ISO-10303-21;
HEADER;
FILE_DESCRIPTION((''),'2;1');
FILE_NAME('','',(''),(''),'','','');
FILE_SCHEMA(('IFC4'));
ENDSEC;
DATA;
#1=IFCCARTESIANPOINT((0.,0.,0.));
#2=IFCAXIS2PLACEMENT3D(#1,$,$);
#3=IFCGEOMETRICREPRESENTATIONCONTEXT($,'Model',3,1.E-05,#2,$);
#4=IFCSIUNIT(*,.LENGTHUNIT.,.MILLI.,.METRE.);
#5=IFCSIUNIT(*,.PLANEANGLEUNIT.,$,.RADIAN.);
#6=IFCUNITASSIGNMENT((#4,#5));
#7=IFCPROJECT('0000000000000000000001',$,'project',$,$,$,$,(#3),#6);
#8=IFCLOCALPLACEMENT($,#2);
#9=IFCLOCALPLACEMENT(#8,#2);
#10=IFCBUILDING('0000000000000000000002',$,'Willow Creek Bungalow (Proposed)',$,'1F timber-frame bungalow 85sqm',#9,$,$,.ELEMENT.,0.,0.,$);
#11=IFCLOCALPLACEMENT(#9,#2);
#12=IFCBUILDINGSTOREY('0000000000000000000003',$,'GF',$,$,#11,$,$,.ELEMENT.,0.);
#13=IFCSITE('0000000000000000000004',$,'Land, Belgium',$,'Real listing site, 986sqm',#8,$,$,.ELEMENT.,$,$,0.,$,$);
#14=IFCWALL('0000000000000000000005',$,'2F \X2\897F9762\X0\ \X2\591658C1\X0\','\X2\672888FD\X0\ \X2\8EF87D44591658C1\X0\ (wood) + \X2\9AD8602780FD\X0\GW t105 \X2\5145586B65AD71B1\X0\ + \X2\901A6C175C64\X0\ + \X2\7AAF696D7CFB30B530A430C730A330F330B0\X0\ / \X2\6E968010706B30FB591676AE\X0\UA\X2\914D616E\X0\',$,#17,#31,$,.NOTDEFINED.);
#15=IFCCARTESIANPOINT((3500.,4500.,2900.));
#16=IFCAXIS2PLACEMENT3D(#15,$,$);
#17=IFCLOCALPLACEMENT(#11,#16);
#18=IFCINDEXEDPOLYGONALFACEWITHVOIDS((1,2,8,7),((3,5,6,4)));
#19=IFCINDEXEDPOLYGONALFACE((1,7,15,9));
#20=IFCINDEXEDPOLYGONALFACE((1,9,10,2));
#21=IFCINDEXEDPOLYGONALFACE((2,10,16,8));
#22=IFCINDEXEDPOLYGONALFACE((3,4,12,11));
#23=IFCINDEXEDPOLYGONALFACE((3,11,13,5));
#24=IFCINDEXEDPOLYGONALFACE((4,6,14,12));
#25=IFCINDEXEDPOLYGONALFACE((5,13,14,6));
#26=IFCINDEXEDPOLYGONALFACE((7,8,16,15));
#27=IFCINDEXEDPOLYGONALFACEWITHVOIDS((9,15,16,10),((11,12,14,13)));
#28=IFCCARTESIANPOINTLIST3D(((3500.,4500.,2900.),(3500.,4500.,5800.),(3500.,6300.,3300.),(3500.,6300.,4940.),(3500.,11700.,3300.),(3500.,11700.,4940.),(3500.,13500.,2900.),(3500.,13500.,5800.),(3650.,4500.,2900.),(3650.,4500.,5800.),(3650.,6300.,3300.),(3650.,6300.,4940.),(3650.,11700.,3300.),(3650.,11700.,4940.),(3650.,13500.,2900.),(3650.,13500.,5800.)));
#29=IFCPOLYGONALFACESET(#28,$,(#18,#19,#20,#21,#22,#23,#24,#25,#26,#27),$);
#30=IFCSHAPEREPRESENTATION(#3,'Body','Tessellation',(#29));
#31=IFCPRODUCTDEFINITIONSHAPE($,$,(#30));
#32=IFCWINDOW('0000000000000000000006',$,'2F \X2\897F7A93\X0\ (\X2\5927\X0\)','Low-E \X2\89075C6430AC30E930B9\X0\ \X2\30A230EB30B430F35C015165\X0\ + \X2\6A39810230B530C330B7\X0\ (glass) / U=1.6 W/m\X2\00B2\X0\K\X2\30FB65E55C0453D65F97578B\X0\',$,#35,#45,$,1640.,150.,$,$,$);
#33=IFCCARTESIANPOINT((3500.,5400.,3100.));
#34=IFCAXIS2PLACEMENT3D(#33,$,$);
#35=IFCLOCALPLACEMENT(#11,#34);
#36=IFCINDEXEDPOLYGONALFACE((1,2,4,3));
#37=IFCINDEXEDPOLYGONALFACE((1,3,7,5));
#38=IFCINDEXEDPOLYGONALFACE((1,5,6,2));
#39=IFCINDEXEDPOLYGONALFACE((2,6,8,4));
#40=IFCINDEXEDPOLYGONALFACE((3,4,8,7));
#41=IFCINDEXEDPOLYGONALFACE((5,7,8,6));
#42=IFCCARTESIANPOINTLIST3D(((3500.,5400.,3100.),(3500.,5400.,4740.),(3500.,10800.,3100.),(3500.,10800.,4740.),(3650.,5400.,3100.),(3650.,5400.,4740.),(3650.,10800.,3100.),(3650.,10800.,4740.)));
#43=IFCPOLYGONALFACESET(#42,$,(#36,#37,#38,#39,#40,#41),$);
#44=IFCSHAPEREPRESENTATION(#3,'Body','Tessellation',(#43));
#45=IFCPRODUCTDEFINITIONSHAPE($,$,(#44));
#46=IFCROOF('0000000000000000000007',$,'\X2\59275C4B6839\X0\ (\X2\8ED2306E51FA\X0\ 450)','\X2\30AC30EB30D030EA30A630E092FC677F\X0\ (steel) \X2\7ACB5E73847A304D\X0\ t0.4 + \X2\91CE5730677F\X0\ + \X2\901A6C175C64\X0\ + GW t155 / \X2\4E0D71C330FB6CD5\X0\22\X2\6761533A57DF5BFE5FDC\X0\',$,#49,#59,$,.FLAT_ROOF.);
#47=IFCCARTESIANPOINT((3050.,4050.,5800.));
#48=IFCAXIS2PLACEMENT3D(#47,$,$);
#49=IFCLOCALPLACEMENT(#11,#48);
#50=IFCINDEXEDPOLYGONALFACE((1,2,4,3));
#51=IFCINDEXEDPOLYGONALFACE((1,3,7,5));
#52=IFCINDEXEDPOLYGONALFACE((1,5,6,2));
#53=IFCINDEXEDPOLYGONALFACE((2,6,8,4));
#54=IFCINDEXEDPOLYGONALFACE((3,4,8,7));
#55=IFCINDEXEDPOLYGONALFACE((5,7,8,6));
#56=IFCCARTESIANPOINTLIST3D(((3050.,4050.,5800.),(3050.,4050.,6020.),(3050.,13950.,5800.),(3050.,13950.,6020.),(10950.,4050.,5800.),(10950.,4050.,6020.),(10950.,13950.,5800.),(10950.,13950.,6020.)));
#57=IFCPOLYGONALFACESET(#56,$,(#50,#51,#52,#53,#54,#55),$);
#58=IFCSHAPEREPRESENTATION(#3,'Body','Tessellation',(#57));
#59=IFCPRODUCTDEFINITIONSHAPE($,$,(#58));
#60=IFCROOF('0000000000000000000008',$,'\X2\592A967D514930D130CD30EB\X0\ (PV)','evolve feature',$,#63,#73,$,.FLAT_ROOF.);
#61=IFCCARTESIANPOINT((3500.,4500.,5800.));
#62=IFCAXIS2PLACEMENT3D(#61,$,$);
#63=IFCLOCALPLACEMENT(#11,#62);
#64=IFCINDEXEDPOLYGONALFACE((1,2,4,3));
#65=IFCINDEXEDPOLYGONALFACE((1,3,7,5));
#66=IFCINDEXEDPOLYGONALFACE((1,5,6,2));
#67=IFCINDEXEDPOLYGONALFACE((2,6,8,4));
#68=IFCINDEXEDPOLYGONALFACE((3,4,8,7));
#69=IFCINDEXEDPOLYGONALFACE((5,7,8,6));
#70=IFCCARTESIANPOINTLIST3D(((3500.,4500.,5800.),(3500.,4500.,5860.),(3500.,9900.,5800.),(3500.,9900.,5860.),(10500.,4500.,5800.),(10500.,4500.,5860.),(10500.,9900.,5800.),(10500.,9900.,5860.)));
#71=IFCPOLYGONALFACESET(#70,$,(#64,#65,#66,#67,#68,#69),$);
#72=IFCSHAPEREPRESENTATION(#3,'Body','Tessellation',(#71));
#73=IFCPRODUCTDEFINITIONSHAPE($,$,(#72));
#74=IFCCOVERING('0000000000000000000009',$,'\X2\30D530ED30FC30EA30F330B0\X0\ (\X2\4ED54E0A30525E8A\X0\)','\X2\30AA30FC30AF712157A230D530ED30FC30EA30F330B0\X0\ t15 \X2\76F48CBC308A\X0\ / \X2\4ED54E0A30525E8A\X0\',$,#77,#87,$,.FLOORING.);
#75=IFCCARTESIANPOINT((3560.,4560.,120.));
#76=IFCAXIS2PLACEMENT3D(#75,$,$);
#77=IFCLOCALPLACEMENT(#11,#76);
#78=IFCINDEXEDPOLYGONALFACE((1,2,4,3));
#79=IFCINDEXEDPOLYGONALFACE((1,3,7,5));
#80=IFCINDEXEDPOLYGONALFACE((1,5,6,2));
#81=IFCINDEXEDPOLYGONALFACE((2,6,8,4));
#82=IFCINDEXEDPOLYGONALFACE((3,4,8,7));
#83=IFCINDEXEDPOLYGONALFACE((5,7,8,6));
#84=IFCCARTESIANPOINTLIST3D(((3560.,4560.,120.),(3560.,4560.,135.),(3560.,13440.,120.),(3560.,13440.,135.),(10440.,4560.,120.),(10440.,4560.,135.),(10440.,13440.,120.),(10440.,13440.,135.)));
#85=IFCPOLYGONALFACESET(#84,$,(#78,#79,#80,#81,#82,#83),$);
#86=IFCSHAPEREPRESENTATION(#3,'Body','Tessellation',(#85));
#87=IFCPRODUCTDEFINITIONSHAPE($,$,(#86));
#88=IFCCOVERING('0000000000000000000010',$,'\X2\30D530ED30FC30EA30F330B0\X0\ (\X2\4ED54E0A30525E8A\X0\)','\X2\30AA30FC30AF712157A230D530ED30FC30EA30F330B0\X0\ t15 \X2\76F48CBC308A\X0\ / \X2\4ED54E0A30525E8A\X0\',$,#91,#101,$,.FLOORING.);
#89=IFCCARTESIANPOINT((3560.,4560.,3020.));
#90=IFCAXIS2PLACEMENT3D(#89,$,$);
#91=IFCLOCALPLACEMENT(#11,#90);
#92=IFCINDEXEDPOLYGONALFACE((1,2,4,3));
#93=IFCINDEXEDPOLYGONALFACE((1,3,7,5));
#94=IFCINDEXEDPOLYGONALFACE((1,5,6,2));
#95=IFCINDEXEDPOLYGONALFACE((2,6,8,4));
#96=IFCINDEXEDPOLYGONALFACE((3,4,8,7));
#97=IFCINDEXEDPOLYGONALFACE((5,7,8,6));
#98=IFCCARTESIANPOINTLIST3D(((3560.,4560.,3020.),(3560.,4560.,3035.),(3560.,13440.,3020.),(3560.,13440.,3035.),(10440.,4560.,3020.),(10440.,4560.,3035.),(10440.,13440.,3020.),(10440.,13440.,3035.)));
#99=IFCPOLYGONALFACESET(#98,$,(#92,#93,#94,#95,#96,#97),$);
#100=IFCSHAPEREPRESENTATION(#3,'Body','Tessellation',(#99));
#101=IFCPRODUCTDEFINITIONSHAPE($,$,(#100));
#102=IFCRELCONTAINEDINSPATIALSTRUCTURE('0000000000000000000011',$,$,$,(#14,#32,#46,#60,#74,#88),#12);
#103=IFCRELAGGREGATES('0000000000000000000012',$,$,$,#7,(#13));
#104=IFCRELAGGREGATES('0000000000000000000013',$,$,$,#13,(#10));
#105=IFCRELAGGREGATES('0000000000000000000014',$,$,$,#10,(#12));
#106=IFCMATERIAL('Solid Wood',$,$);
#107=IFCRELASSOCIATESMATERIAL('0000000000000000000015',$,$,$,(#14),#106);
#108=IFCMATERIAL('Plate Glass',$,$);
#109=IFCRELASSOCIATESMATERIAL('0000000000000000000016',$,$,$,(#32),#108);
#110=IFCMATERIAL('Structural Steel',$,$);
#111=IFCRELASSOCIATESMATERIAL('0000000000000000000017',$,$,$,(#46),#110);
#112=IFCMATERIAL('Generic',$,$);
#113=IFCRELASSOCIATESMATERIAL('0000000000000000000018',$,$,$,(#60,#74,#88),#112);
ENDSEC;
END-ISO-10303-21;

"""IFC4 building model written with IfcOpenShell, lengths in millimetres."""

from ifc_helpers import new_model, si_unit, frame, frame_2d, origin, place, context, project, spatial, rectangle, extrude, material, element, fill, save


model = new_model("IFC4")

# Units and contexts
model_context = context("Model", 3, precision=1e-05, world=origin())
ifc_project = project(units=[si_unit("LENGTHUNIT", "METRE", prefix="MILLI"), si_unit("PLANEANGLEUNIT", "RADIAN")], contexts=[model_context])

# Site, building, storey
site_placement = place(None, origin())
site = spatial("IfcSite", under=ifc_project, at=site_placement, Name="Land, Belgium", ObjectType="Real listing site, 986sqm", CompositionType="ELEMENT", RefElevation=0.0)
building_placement = place(site_placement, origin())
building = spatial("IfcBuilding", under=site, at=building_placement, Name="Willow Creek Bungalow (Proposed)", ObjectType="1F timber-frame bungalow 85sqm", CompositionType="ELEMENT", ElevationOfRefHeight=0.0, ElevationOfTerrain=0.0)
storey_placement = place(building_placement, origin())
storey = spatial("IfcBuildingStorey", under=building, at=storey_placement, Name="GF", CompositionType="ELEMENT", Elevation=0.0)

# Shared definitions
ifc_material_1 = material(Name="Solid Wood")
ifc_material_2 = material(Name="Generic")

# Shared definitions
ifc_material_3 = material(Name="Plate Glass")

# Wall, opening, window
wall_1_placement = place(storey_placement, frame((3500.0, 4500.0, 2900.0)))
wall_1 = element("IfcWall", 1, at=wall_1_placement, inside=storey, material=ifc_material_1, Name="2F 西面 外壁", Description="木製 軸組外壁 (wood) + 高性能GW t105 充填断熱 + 通気層 + 窯業系サイディング / 準耐火・外皮UA配慮", PredefinedType="NOTDEFINED", context=model_context, shape_type="SweptSolid", body=[
    extrude(rectangle(XDim=150.0, YDim=9000.0, at=frame_2d((75.0, 4500.0))), frame((3500.0, 4500.0, 2900.0)), (0.0, 0.0, 1.0), 2900.0),
])
opening_1_placement = place(storey_placement, frame((3500.0, 5400.0, 3100.0)))
opening_1 = element("IfcOpeningElement", 2, at=opening_1_placement, cuts=wall_1, PredefinedType="NOTDEFINED", context=model_context, shape_type="SweptSolid", body=[
    extrude(rectangle(XDim=150.0, YDim=5400.0, at=frame_2d((75.0, 2700.0))), frame((3500.0, 5400.0, 3100.0)), (0.0, 0.0, 1.0), 1640.0),
])
window_1_placement = place(storey_placement, frame((3500.0, 5400.0, 3100.0)))
window_1 = element("IfcWindow", 3, at=window_1_placement, inside=storey, material=ifc_material_3, Name="2F 西窓 (大)", Description="Low-E 複層ガラス アルゴン封入 + 樹脂サッシ (glass) / U=1.6 W/m²K・日射取得型", OverallHeight=1640.0, OverallWidth=150.0, context=model_context, shape_type="SweptSolid", body=[
    extrude(rectangle(XDim=150.0, YDim=5400.0, at=frame_2d((75.0, 2700.0))), frame((3500.0, 5400.0, 3100.0)), (0.0, 0.0, 1.0), 1640.0),
])
fill(opening_1, window_1)

# Roofs
ifc_material_4 = material(Name="Structural Steel")
roof_1_placement = place(storey_placement, frame((3050.0, 4050.0, 5800.0)))
element("IfcRoof", 4, at=roof_1_placement, inside=storey, material=ifc_material_4, Name="大屋根 (軒の出 450)", Description="ガルバリウム鋼板 (steel) 立平葺き t0.4 + 野地板 + 通気層 + GW t155 / 不燃・法22条区域対応", PredefinedType="FLAT_ROOF", context=model_context, shape_type="SweptSolid", body=[
    extrude(rectangle(XDim=7900.0, YDim=9900.0, at=frame_2d((3950.0, 4950.0))), frame((3050.0, 4050.0, 5800.0)), (0.0, 0.0, 1.0), 220.0),
])
roof_2_placement = place(storey_placement, frame((3500.0, 4500.0, 5800.0)))
element("IfcRoof", 5, at=roof_2_placement, inside=storey, material=ifc_material_2, Name="太陽光パネル (PV)", Description="evolve feature", PredefinedType="FLAT_ROOF", context=model_context, shape_type="SweptSolid", body=[
    extrude(rectangle(XDim=7000.0, YDim=5400.0, at=frame_2d((3500.0, 2700.0))), frame((3500.0, 4500.0, 5800.0)), (0.0, 0.0, 1.0), 60.0),
])

# Coverings
covering_1_placement = place(storey_placement, frame((3560.0, 4560.0, 120.0)))
element("IfcCovering", 6, at=covering_1_placement, inside=storey, material=ifc_material_2, Name="フローリング (仕上げ床)", Description="オーク無垢フローリング t15 直貼り / 仕上げ床", PredefinedType="FLOORING", context=model_context, shape_type="SweptSolid", body=[
    extrude(rectangle(XDim=6880.0, YDim=8880.0, at=frame_2d((3440.0, 4440.0))), frame((3560.0, 4560.0, 120.0)), (0.0, 0.0, 1.0), 15.0),
])
covering_2_placement = place(storey_placement, frame((3560.0, 4560.0, 3020.0)))
element("IfcCovering", 7, at=covering_2_placement, inside=storey, material=ifc_material_2, Name="フローリング (仕上げ床)", Description="オーク無垢フローリング t15 直貼り / 仕上げ床", PredefinedType="FLOORING", context=model_context, shape_type="SweptSolid", body=[
    extrude(rectangle(XDim=6880.0, YDim=8880.0, at=frame_2d((3440.0, 4440.0))), frame((3560.0, 4560.0, 3020.0)), (0.0, 0.0, 1.0), 15.0),
])

save(model, "model.ifc")
